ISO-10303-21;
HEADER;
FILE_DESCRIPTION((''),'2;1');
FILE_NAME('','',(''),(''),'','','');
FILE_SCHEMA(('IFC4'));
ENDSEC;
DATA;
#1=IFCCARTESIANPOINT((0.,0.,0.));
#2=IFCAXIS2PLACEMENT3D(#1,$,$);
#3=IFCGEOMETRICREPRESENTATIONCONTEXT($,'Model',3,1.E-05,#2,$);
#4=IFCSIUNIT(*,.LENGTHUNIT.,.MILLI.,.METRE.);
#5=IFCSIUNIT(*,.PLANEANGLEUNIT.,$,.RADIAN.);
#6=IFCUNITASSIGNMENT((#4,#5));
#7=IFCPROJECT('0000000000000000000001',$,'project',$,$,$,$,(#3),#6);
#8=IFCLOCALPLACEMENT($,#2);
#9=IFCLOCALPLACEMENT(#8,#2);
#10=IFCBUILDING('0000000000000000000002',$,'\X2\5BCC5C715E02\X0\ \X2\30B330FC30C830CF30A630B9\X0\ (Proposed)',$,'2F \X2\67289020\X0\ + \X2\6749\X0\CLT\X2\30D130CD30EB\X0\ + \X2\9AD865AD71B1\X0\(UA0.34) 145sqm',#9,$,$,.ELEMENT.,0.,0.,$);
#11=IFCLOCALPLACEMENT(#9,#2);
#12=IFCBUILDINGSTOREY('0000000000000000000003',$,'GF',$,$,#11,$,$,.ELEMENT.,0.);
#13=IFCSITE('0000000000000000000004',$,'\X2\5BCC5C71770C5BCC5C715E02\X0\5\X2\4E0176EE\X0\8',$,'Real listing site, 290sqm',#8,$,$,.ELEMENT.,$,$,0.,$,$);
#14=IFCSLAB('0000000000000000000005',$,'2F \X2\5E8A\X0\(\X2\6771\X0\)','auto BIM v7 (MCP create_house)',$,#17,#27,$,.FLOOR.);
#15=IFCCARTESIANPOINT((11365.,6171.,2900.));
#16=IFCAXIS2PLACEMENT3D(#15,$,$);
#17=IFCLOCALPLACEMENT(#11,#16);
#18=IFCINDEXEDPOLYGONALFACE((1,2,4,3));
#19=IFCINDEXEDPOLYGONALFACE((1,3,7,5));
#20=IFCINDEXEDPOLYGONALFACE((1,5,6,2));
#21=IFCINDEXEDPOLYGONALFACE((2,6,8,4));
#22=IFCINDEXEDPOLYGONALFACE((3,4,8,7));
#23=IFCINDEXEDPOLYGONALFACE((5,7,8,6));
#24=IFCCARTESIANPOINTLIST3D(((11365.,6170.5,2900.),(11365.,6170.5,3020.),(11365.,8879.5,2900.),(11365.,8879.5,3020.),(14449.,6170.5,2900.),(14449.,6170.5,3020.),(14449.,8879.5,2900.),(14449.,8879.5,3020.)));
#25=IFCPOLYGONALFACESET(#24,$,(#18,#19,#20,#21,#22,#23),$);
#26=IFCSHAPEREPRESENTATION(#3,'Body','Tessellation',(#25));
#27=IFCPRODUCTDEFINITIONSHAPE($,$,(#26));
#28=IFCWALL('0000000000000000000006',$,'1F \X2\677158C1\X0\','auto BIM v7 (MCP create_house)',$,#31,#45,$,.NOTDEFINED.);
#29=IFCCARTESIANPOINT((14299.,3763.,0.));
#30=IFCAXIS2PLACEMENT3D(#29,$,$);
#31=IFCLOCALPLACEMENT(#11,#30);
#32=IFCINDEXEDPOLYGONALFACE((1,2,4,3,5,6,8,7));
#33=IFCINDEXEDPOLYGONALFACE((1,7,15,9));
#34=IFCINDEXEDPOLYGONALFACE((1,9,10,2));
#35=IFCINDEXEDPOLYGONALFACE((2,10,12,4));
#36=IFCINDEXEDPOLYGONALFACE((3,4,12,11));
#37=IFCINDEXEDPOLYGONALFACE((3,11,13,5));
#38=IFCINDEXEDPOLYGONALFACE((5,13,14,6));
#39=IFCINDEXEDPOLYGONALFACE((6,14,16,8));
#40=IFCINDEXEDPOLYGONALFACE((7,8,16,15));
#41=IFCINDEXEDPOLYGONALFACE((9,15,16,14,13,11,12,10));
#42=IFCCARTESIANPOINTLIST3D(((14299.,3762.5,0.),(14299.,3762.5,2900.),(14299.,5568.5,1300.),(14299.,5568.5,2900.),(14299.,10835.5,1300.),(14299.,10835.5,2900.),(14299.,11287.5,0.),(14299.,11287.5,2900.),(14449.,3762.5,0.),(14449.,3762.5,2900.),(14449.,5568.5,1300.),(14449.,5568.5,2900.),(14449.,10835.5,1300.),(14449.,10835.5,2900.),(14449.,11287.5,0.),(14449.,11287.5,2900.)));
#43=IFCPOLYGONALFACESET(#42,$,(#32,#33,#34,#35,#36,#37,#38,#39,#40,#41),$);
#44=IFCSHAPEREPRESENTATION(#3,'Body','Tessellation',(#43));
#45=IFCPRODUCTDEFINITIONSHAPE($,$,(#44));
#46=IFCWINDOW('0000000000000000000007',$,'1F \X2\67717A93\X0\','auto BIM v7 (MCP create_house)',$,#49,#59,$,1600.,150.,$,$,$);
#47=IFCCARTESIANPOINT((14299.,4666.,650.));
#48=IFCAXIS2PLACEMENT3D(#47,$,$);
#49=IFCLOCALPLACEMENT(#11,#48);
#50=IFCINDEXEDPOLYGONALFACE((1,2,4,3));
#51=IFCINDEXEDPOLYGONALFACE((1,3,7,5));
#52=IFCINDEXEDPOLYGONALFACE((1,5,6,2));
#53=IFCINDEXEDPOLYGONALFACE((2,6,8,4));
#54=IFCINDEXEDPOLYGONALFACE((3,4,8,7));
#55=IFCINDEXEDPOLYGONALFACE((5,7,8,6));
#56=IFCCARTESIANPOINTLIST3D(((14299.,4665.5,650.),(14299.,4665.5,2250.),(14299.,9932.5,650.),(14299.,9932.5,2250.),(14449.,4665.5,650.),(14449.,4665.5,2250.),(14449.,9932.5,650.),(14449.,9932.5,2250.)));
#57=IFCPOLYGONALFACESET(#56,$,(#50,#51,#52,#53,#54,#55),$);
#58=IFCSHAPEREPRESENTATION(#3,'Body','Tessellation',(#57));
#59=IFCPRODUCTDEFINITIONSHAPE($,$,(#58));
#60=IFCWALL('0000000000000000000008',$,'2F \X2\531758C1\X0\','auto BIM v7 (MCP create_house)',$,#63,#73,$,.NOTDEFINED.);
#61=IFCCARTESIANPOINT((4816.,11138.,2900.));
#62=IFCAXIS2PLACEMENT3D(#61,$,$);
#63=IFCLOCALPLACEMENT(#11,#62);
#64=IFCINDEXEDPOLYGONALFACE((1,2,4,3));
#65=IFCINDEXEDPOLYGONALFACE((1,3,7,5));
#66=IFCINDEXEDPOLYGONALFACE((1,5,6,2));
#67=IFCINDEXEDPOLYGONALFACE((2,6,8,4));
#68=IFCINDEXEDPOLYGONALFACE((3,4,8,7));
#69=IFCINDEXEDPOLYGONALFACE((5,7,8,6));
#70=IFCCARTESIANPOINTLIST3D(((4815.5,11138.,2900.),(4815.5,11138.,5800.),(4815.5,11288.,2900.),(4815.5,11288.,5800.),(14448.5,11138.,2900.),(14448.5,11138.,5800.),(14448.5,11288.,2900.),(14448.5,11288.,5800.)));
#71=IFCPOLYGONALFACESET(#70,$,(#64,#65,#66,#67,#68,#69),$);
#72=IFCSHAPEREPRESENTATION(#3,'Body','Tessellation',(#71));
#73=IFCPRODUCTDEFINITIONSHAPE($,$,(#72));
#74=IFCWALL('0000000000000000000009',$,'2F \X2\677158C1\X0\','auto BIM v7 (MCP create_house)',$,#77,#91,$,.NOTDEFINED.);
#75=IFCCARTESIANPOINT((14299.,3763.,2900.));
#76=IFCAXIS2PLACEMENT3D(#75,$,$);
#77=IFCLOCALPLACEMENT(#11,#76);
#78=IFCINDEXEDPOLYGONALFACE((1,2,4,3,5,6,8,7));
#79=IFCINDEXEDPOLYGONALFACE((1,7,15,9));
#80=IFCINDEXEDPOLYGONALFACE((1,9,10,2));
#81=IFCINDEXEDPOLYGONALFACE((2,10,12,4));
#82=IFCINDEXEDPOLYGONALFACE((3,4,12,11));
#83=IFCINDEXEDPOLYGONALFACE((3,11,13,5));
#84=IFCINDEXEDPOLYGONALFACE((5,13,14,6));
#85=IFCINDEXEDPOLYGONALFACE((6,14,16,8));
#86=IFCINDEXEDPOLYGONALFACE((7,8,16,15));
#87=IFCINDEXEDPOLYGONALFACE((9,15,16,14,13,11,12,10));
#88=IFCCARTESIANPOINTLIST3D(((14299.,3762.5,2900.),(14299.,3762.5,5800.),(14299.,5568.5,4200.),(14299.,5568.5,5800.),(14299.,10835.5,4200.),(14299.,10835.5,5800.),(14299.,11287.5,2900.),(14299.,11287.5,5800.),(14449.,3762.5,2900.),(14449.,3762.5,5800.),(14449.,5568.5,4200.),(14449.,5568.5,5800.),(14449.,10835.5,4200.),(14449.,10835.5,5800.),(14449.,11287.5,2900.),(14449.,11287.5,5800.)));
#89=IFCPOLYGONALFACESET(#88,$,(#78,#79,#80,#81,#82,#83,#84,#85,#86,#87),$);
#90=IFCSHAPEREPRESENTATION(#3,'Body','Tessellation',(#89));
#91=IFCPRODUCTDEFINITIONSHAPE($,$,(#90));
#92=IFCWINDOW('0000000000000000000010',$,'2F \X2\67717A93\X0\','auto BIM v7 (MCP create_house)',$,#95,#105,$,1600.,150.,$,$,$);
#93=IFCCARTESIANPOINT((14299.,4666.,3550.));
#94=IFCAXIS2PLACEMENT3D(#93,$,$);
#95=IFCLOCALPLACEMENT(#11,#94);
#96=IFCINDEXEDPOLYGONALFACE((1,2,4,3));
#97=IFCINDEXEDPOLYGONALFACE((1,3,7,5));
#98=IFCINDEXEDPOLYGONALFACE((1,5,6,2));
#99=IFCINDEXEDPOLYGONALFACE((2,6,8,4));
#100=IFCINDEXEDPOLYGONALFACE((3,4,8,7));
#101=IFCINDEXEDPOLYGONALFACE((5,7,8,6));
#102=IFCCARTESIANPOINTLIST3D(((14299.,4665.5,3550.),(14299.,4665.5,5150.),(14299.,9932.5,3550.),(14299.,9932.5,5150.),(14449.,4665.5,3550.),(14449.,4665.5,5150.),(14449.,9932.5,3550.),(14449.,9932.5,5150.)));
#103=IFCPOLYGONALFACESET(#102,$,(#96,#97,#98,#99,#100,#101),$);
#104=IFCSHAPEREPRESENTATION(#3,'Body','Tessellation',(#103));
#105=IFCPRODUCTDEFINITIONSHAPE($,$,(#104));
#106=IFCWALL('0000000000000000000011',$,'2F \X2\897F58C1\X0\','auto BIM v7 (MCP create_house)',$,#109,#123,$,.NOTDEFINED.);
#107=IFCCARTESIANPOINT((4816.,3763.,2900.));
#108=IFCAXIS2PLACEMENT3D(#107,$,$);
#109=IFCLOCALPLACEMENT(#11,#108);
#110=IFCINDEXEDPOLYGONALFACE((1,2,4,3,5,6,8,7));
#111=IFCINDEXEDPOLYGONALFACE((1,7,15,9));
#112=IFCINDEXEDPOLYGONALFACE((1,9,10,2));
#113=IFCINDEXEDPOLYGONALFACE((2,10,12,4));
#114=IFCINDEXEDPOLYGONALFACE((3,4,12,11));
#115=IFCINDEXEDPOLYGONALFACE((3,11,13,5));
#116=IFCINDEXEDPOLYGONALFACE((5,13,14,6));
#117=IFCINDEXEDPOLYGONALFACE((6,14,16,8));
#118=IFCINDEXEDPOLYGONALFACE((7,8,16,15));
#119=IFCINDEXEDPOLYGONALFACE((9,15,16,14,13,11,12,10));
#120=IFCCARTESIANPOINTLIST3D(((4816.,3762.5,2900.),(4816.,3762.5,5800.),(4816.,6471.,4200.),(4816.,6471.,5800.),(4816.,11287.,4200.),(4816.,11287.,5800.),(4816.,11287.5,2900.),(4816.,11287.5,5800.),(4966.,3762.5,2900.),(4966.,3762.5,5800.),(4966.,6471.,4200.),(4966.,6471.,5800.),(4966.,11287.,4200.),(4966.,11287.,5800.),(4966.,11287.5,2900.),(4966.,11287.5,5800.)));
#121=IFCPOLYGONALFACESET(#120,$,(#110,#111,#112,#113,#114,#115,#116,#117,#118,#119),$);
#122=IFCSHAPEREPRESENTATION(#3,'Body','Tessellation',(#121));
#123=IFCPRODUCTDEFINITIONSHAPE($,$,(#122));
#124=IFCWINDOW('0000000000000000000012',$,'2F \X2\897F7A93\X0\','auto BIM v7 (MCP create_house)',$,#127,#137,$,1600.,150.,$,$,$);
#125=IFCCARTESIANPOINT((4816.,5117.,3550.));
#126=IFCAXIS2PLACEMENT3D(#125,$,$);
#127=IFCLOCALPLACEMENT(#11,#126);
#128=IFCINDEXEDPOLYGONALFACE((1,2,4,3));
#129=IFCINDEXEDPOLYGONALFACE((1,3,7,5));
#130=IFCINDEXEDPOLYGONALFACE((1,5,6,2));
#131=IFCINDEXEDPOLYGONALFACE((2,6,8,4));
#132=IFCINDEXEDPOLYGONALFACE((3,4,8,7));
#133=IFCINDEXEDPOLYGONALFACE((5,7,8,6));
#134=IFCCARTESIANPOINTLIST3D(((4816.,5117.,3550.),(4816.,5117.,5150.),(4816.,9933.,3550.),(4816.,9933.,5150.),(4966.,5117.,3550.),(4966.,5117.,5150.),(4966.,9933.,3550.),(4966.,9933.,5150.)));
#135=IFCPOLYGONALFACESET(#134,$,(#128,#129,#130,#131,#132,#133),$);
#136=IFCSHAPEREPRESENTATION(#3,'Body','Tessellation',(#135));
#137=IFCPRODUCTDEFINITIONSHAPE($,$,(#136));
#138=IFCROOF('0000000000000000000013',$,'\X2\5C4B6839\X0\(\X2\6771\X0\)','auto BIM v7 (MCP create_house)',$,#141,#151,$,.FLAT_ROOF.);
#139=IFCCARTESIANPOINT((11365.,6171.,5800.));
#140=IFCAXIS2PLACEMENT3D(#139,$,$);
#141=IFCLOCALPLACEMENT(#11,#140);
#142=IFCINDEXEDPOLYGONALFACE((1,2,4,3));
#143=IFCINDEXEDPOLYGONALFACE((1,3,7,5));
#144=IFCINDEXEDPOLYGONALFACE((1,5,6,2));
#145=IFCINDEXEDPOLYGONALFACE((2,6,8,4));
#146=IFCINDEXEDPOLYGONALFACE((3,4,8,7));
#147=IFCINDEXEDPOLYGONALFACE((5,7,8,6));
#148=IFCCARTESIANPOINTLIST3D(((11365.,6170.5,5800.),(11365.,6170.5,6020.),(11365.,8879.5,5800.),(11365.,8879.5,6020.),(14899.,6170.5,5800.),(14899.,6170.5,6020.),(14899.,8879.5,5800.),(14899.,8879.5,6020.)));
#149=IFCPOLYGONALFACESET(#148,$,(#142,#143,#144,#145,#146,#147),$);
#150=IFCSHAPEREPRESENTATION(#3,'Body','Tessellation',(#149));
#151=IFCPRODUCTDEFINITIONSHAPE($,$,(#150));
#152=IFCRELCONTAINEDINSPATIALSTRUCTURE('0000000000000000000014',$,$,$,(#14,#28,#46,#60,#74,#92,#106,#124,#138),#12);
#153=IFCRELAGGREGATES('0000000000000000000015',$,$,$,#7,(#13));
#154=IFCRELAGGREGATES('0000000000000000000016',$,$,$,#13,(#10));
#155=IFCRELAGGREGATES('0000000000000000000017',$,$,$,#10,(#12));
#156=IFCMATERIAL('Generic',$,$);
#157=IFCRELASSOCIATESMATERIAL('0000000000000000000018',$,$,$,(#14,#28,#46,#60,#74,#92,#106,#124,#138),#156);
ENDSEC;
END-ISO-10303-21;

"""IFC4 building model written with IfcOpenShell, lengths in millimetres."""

from ifc_helpers import new_model, si_unit, frame, frame_2d, origin, place, context, project, spatial, rectangle, extrude, material, element, fill, save


model = new_model("IFC4")

# Units and contexts
model_context = context("Model", 3, precision=1e-05, world=origin())
ifc_project = project(units=[si_unit("LENGTHUNIT", "METRE", prefix="MILLI"), si_unit("PLANEANGLEUNIT", "RADIAN")], contexts=[model_context])

# Site, building, storey
site_placement = place(None, origin())
site = spatial("IfcSite", under=ifc_project, at=site_placement, Name="富山県富山市5丁目8", ObjectType="Real listing site, 290sqm", CompositionType="ELEMENT", RefElevation=0.0)
building_placement = place(site_placement, origin())
building = spatial("IfcBuilding", under=site, at=building_placement, Name="富山市 コートハウス (Proposed)", ObjectType="2F 木造 + 杉CLTパネル + 高断熱(UA0.34) 145sqm", CompositionType="ELEMENT", ElevationOfRefHeight=0.0, ElevationOfTerrain=0.0)
storey_placement = place(building_placement, origin())
storey = spatial("IfcBuildingStorey", under=building, at=storey_placement, Name="GF", CompositionType="ELEMENT", Elevation=0.0)

# Slab
ifc_material = material(Name="Generic")
slab_1_placement = place(storey_placement, frame((11365.0, 6171.0, 2900.0)))
element("IfcSlab", 1, at=slab_1_placement, inside=storey, material=ifc_material, Name="2F 床(東)", Description="auto BIM v7 (MCP create_house)", PredefinedType="FLOOR", context=model_context, shape_type="SweptSolid", body=[
    extrude(rectangle(XDim=3084.0, YDim=2709.0, at=frame_2d((1542.0, 1354.0))), frame((11365.0, 6171.0, 2900.0)), (0.0, 0.0, 1.0), 120.0),
])

# Wall, opening, window
wall_1_placement = place(storey_placement, frame((14299.0, 3763.0, 0.0)))
wall_1 = element("IfcWall", 2, at=wall_1_placement, inside=storey, material=ifc_material, Name="1F 東壁", Description="auto BIM v7 (MCP create_house)", PredefinedType="NOTDEFINED", context=model_context, shape_type="SweptSolid", body=[
    extrude(rectangle(XDim=150.0, YDim=7525.0, at=frame_2d((75.0, 3762.0))), frame((14299.0, 3763.0, 0.0)), (0.0, 0.0, 1.0), 2900.0),
])
opening_1_placement = place(storey_placement, frame((14299.0, 4666.0, 650.0)))
opening_1 = element("IfcOpeningElement", 3, at=opening_1_placement, cuts=wall_1, PredefinedType="NOTDEFINED", context=model_context, shape_type="SweptSolid", body=[
    extrude(rectangle(XDim=150.0, YDim=5267.0, at=frame_2d((75.0, 2633.0))), frame((14299.0, 4666.0, 650.0)), (0.0, 0.0, 1.0), 1600.0),
])
window_1_placement = place(storey_placement, frame((14299.0, 4666.0, 650.0)))
window_1 = element("IfcWindow", 4, at=window_1_placement, inside=storey, material=ifc_material, Name="1F 東窓", Description="auto BIM v7 (MCP create_house)", OverallHeight=1600.0, OverallWidth=150.0, context=model_context, shape_type="SweptSolid", body=[
    extrude(rectangle(XDim=150.0, YDim=5267.0, at=frame_2d((75.0, 2633.0))), frame((14299.0, 4666.0, 650.0)), (0.0, 0.0, 1.0), 1600.0),
])
fill(opening_1, window_1)

# Wall
wall_2_placement = place(storey_placement, frame((4816.0, 11138.0, 2900.0)))
element("IfcWall", 5, at=wall_2_placement, inside=storey, material=ifc_material, Name="2F 北壁", Description="auto BIM v7 (MCP create_house)", PredefinedType="NOTDEFINED", context=model_context, shape_type="SweptSolid", body=[
    extrude(rectangle(XDim=9633.0, YDim=150.0, at=frame_2d((4816.0, 75.0))), frame((4816.0, 11138.0, 2900.0)), (0.0, 0.0, 1.0), 2900.0),
])

# Walls, openings, windows
wall_3_placement = place(storey_placement, frame((14299.0, 3763.0, 2900.0)))
wall_3 = element("IfcWall", 6, at=wall_3_placement, inside=storey, material=ifc_material, Name="2F 東壁", Description="auto BIM v7 (MCP create_house)", PredefinedType="NOTDEFINED", context=model_context, shape_type="SweptSolid", body=[
    extrude(rectangle(XDim=150.0, YDim=7525.0, at=frame_2d((75.0, 3762.0))), frame((14299.0, 3763.0, 2900.0)), (0.0, 0.0, 1.0), 2900.0),
])
opening_2_placement = place(storey_placement, frame((14299.0, 4666.0, 3550.0)))
opening_2 = element("IfcOpeningElement", 7, at=opening_2_placement, cuts=wall_3, PredefinedType="NOTDEFINED", context=model_context, shape_type="SweptSolid", body=[
    extrude(rectangle(XDim=150.0, YDim=5267.0, at=frame_2d((75.0, 2633.0))), frame((14299.0, 4666.0, 3550.0)), (0.0, 0.0, 1.0), 1600.0),
])
window_2_placement = place(storey_placement, frame((14299.0, 4666.0, 3550.0)))
window_2 = element("IfcWindow", 8, at=window_2_placement, inside=storey, material=ifc_material, Name="2F 東窓", Description="auto BIM v7 (MCP create_house)", OverallHeight=1600.0, OverallWidth=150.0, context=model_context, shape_type="SweptSolid", body=[
    extrude(rectangle(XDim=150.0, YDim=5267.0, at=frame_2d((75.0, 2633.0))), frame((14299.0, 4666.0, 3550.0)), (0.0, 0.0, 1.0), 1600.0),
])
fill(opening_2, window_2)
wall_4_placement = place(storey_placement, frame((4816.0, 3763.0, 2900.0)))
wall_4 = element("IfcWall", 9, at=wall_4_placement, inside=storey, material=ifc_material, Name="2F 西壁", Description="auto BIM v7 (MCP create_house)", PredefinedType="NOTDEFINED", context=model_context, shape_type="SweptSolid", body=[
    extrude(rectangle(XDim=150.0, YDim=7525.0, at=frame_2d((75.0, 3762.0))), frame((4816.0, 3763.0, 2900.0)), (0.0, 0.0, 1.0), 2900.0),
])
opening_3_placement = place(storey_placement, frame((4816.0, 5117.0, 3550.0)))
opening_3 = element("IfcOpeningElement", 10, at=opening_3_placement, cuts=wall_4, PredefinedType="NOTDEFINED", context=model_context, shape_type="SweptSolid", body=[
    extrude(rectangle(XDim=150.0, YDim=4816.0, at=frame_2d((75.0, 2408.0))), frame((4816.0, 5117.0, 3550.0)), (0.0, 0.0, 1.0), 1600.0),
])
window_3_placement = place(storey_placement, frame((4816.0, 5117.0, 3550.0)))
window_3 = element("IfcWindow", 11, at=window_3_placement, inside=storey, material=ifc_material, Name="2F 西窓", Description="auto BIM v7 (MCP create_house)", OverallHeight=1600.0, OverallWidth=150.0, context=model_context, shape_type="SweptSolid", body=[
    extrude(rectangle(XDim=150.0, YDim=4816.0, at=frame_2d((75.0, 2408.0))), frame((4816.0, 5117.0, 3550.0)), (0.0, 0.0, 1.0), 1600.0),
])
fill(opening_3, window_3)

# Roof
for number, where, name in (
    (12, (11365.0, 6171.0, 5800.0), "屋根(東)"),
):
    element("IfcRoof", number, at=place(storey_placement, frame(where)), inside=storey, material=ifc_material, Name=name, Description="auto BIM v7 (MCP create_house)", PredefinedType="FLAT_ROOF", context=model_context, shape_type="SweptSolid", body=[
        extrude(rectangle(XDim=3534.0, YDim=2709.0, at=frame_2d((1767.0, 1354.0))), frame((11365.0, 6171.0, 5800.0)), (0.0, 0.0, 1.0), 220.0),
    ])

save(model, "model.ifc")
